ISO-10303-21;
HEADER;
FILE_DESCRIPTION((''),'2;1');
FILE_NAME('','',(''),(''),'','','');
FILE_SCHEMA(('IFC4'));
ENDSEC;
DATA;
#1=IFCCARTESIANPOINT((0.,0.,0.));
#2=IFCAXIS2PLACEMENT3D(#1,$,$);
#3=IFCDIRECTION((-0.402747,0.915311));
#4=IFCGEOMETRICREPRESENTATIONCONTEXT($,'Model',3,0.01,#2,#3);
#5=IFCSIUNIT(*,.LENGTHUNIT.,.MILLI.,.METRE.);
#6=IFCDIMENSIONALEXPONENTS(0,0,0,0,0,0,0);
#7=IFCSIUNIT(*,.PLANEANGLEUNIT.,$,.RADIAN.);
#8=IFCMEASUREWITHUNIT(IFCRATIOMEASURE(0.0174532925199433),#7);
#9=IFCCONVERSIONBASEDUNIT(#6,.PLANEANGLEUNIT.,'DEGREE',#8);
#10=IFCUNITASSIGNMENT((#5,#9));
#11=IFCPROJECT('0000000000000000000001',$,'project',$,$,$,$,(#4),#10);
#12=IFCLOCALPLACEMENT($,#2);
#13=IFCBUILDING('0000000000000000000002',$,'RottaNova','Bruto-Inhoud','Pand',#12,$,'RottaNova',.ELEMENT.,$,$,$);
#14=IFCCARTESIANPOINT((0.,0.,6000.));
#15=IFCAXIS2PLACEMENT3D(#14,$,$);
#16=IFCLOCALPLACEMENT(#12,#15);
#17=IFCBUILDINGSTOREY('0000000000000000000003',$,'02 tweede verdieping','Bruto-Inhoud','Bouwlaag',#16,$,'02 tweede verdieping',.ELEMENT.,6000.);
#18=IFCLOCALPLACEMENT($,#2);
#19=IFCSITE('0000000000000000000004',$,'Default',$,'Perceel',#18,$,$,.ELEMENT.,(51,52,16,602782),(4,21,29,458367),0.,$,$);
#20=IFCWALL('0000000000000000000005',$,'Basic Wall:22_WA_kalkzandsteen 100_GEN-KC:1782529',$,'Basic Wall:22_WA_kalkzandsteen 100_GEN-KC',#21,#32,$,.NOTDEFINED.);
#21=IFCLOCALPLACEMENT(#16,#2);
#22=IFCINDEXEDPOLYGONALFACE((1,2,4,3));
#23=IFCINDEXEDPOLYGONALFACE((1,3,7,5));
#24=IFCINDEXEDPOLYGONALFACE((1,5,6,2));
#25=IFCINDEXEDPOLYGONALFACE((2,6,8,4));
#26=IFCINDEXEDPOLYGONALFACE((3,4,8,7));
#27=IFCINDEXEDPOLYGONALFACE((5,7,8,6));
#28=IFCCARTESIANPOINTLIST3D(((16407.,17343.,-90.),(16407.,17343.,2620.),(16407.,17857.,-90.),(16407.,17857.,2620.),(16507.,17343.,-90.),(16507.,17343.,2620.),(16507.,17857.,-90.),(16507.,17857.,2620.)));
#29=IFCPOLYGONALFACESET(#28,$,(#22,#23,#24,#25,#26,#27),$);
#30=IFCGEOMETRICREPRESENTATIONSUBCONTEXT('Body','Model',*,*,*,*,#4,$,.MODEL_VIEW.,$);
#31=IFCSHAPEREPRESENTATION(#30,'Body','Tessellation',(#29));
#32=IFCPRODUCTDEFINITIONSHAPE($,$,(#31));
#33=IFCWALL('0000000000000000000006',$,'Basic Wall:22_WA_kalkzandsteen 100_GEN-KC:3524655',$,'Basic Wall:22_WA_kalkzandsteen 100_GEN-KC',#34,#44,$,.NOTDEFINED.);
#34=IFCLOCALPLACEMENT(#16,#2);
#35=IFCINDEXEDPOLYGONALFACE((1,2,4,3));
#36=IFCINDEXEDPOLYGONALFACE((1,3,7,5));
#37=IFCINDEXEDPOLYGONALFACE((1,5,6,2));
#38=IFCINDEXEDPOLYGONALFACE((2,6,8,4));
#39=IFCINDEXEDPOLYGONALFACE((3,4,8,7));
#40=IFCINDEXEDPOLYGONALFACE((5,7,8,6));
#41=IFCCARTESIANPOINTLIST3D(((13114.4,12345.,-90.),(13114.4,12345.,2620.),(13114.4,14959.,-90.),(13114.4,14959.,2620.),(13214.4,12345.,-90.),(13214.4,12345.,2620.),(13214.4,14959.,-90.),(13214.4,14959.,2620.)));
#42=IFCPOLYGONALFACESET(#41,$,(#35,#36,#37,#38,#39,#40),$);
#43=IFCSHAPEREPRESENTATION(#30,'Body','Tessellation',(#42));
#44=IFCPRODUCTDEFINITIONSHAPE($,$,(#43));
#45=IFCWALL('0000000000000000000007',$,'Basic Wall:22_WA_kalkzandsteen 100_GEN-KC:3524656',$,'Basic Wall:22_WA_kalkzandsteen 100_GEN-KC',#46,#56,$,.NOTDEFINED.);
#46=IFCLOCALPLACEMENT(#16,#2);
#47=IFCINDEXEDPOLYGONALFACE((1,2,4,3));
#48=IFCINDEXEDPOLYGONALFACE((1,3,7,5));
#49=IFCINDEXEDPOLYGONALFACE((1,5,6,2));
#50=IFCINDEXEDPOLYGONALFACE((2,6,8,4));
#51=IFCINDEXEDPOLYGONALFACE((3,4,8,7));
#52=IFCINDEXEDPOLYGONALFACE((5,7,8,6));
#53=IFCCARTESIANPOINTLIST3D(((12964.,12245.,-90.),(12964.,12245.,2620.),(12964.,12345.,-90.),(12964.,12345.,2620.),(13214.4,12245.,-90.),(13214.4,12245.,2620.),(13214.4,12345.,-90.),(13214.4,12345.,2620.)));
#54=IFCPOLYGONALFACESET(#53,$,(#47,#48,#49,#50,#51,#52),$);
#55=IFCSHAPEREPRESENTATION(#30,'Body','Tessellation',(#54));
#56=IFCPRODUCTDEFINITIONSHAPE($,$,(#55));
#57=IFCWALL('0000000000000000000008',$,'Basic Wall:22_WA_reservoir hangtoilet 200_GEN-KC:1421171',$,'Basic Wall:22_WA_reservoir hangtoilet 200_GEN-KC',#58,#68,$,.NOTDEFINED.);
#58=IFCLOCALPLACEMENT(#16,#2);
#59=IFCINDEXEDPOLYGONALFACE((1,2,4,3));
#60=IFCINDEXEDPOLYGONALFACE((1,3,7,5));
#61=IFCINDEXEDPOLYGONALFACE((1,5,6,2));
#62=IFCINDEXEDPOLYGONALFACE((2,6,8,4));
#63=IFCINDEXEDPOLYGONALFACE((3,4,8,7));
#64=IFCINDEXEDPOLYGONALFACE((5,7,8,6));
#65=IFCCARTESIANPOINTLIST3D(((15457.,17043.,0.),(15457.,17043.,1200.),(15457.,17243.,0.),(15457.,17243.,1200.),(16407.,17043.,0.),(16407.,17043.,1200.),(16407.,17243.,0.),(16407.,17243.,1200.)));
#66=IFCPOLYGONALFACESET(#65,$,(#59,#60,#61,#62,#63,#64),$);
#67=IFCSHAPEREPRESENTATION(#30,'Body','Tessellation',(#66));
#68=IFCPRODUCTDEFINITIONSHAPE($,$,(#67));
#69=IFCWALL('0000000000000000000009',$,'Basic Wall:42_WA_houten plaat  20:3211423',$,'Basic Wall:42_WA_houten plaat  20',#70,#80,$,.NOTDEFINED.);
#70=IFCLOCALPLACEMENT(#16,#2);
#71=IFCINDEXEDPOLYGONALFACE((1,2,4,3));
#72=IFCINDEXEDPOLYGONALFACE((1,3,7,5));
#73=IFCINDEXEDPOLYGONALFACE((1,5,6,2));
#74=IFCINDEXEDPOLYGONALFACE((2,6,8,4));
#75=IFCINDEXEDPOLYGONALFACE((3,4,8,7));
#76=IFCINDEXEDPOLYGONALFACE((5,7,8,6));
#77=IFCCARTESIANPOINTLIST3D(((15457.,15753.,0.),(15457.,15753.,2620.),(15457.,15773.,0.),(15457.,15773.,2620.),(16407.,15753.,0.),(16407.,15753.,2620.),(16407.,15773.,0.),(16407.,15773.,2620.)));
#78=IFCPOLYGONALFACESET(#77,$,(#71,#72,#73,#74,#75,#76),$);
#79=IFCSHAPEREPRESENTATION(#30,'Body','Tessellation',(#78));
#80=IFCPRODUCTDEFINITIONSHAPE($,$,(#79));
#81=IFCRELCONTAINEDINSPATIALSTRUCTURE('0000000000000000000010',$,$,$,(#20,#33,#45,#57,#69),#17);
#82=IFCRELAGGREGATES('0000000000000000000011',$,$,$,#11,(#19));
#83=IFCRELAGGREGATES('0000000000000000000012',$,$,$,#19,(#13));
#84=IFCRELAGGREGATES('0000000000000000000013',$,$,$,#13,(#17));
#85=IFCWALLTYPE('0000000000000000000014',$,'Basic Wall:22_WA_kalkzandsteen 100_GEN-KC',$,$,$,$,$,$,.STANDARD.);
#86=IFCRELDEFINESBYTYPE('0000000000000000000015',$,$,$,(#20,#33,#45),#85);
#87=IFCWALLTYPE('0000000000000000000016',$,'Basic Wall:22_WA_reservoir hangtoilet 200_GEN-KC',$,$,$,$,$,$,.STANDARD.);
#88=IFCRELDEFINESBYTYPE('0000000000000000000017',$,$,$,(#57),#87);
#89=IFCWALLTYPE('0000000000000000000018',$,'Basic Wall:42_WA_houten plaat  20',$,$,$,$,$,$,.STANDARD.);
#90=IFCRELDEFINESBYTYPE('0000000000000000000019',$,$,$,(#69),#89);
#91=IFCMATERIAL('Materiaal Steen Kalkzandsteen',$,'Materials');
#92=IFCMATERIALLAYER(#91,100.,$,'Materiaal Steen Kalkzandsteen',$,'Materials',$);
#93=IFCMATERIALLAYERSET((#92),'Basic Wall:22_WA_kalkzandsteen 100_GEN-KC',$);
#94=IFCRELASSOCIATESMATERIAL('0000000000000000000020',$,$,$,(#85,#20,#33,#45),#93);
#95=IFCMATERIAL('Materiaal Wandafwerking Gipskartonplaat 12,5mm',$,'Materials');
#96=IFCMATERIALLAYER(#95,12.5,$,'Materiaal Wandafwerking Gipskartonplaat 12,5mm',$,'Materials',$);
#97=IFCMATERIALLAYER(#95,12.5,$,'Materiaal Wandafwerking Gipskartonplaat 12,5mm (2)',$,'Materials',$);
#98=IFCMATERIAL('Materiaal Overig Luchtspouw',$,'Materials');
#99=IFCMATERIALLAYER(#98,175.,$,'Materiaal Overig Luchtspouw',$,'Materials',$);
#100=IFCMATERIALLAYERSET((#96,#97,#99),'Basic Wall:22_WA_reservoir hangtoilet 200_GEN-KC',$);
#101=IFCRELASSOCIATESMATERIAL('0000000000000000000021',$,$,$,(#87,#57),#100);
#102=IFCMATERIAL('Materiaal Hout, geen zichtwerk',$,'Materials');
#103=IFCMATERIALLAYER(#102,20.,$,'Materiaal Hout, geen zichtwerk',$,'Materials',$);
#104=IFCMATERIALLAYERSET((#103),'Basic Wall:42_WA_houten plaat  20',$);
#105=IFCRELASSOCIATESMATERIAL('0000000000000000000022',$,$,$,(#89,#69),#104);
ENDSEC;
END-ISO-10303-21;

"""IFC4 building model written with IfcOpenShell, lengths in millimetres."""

from ifc_helpers import new_model, entity, si_unit, converted_unit, direction, frame, frame_2d, origin, place, context, subcontext, project, spatial, rectangle, extrude, material, layer, layer_set, type_object, element, save


model = new_model("IFC4")

# Units and contexts
model_context = context("Model", 3, precision=0.01, world=origin(), true_north=direction((-0.402747, 0.915311)))
body_context = subcontext(model_context, "Body", "Model", "MODEL_VIEW")
ifc_project = project(units=[si_unit("LENGTHUNIT", "METRE", prefix="MILLI"), converted_unit("PLANEANGLEUNIT", "DEGREE", entity("IfcRatioMeasure", 0.0174532925199433), si_unit("PLANEANGLEUNIT", "RADIAN"), dimensions=[0, 0, 0, 0, 0, 0, 0])], contexts=[model_context])

# Site, building, storey
site_placement = place(None, origin())
site = spatial("IfcSite", under=ifc_project, at=site_placement, Name="Default", ObjectType="Perceel", CompositionType="ELEMENT", RefLatitude=(51, 52, 16, 602782), RefLongitude=(4, 21, 29, 458367), RefElevation=0.0)
building_placement = place(None, origin())
building = spatial("IfcBuilding", under=site, at=building_placement, Name="RottaNova", Description="Bruto-Inhoud", ObjectType="Pand", LongName="RottaNova", CompositionType="ELEMENT")
storey_placement = place(building_placement, frame((0.0, 0.0, 6000.0)))
storey = spatial("IfcBuildingStorey", under=building, at=storey_placement, Name="02 tweede verdieping", Description="Bruto-Inhoud", ObjectType="Bouwlaag", LongName="02 tweede verdieping", CompositionType="ELEMENT", Elevation=6000.0)

# Shared definitions
ifc_material_1 = material(Name="Materiaal Steen Kalkzandsteen", Category="Materials")

# Walls
ifc_material_2 = material(Name="Materiaal Wandafwerking Gipskartonplaat 12,5mm", Category="Materials")
ifc_layer_1 = layer(ifc_material_1, 100.0, Name="Materiaal Steen Kalkzandsteen", Category="Materials")
ifc_layer_set_1 = layer_set([ifc_layer_1], Name="Basic Wall:22_WA_kalkzandsteen 100_GEN-KC")
wall_type_1 = type_object("IfcWallType", Name="Basic Wall:22_WA_kalkzandsteen 100_GEN-KC", PredefinedType="STANDARD", material=ifc_layer_set_1)
wall_1_placement = place(storey_placement, frame((16457.0, 17343.0, -90.0), z_axis=(0.0, 0.0, 1.0), x_axis=(0.0, 1.0, 0.0)))
element("IfcWall", 1, at=wall_1_placement, inside=storey, type_object=wall_type_1, material=ifc_layer_set_1, Name="Basic Wall:22_WA_kalkzandsteen 100_GEN-KC:1782529", ObjectType="Basic Wall:22_WA_kalkzandsteen 100_GEN-KC", PredefinedType="NOTDEFINED", context=body_context, shape_type="SweptSolid", body=[
    extrude(rectangle(XDim=514.0, YDim=100.0, at=frame_2d((257.0, 0.0), x_axis=(-1.0, 0.0))), origin(), (0.0, 0.0, 1.0), 2710.0),
])
wall_2_placement = place(storey_placement, frame((13164.4, 14959.0, -90.0), z_axis=(0.0, 0.0, 1.0), x_axis=(0.0, -1.0, 0.0)))
element("IfcWall", 2, at=wall_2_placement, inside=storey, type_object=wall_type_1, material=ifc_layer_set_1, Name="Basic Wall:22_WA_kalkzandsteen 100_GEN-KC:3524655", ObjectType="Basic Wall:22_WA_kalkzandsteen 100_GEN-KC", PredefinedType="NOTDEFINED", context=body_context, shape_type="SweptSolid", body=[
    extrude(rectangle(XDim=2614.0, YDim=100.0, at=frame_2d((1307.0, 0.0), x_axis=(-1.0, 0.0))), origin(), (0.0, 0.0, 1.0), 2710.0),
])
wall_3_placement = place(storey_placement, frame((13214.4, 12295.0, -90.0), z_axis=(0.0, 0.0, 1.0), x_axis=(-1.0, 0.0, 0.0)))
element("IfcWall", 3, at=wall_3_placement, inside=storey, type_object=wall_type_1, material=ifc_layer_set_1, Name="Basic Wall:22_WA_kalkzandsteen 100_GEN-KC:3524656", ObjectType="Basic Wall:22_WA_kalkzandsteen 100_GEN-KC", PredefinedType="NOTDEFINED", context=body_context, shape_type="SweptSolid", body=[
    extrude(rectangle(XDim=250.4, YDim=100.0, at=frame_2d((125.2, 0.0), x_axis=(-1.0, 0.0))), origin(), (0.0, 0.0, 1.0), 2710.0),
])
ifc_layer_2 = layer(ifc_material_2, 12.5, Name="Materiaal Wandafwerking Gipskartonplaat 12,5mm", Category="Materials")
ifc_layer_3 = layer(ifc_material_2, 12.5, Name="Materiaal Wandafwerking Gipskartonplaat 12,5mm (2)", Category="Materials")
ifc_material_3 = material(Name="Materiaal Overig Luchtspouw", Category="Materials")
ifc_layer_4 = layer(ifc_material_3, 175.0, Name="Materiaal Overig Luchtspouw", Category="Materials")
ifc_layer_set_2 = layer_set([ifc_layer_2, ifc_layer_3, ifc_layer_4], Name="Basic Wall:22_WA_reservoir hangtoilet 200_GEN-KC")
wall_type_2 = type_object("IfcWallType", Name="Basic Wall:22_WA_reservoir hangtoilet 200_GEN-KC", PredefinedType="STANDARD", material=ifc_layer_set_2)
wall_4_placement = place(storey_placement, frame((16407.0, 17143.0, 0.0), z_axis=(0.0, 0.0, 1.0), x_axis=(-1.0, 0.0, 0.0)))
element("IfcWall", 4, at=wall_4_placement, inside=storey, type_object=wall_type_2, material=ifc_layer_set_2, Name="Basic Wall:22_WA_reservoir hangtoilet 200_GEN-KC:1421171", ObjectType="Basic Wall:22_WA_reservoir hangtoilet 200_GEN-KC", PredefinedType="NOTDEFINED", context=body_context, shape_type="SweptSolid", body=[
    extrude(rectangle(XDim=950.0, YDim=200.0, at=frame_2d((475.0, 0.0), x_axis=(-1.0, 0.0))), origin(), (0.0, 0.0, 1.0), 1200.0),
])
ifc_material_4 = material(Name="Materiaal Hout, geen zichtwerk", Category="Materials")
ifc_layer_5 = layer(ifc_material_4, 20.0, Name="Materiaal Hout, geen zichtwerk", Category="Materials")
ifc_layer_set_3 = layer_set([ifc_layer_5], Name="Basic Wall:42_WA_houten plaat  20")
wall_type_3 = type_object("IfcWallType", Name="Basic Wall:42_WA_houten plaat  20", PredefinedType="STANDARD", material=ifc_layer_set_3)
wall_5_placement = place(storey_placement, frame((16407.0, 15763.0, 0.0), z_axis=(0.0, 0.0, 1.0), x_axis=(-1.0, 0.0, 0.0)))
element("IfcWall", 5, at=wall_5_placement, inside=storey, type_object=wall_type_3, material=ifc_layer_set_3, Name="Basic Wall:42_WA_houten plaat  20:3211423", ObjectType="Basic Wall:42_WA_houten plaat  20", PredefinedType="NOTDEFINED", context=body_context, shape_type="SweptSolid", body=[
    extrude(rectangle(XDim=950.0, YDim=20.0, at=frame_2d((475.0, 0.0), x_axis=(-1.0, 0.0))), origin(), (0.0, 0.0, 1.0), 2620.0),
])

save(model, "model.ifc")
